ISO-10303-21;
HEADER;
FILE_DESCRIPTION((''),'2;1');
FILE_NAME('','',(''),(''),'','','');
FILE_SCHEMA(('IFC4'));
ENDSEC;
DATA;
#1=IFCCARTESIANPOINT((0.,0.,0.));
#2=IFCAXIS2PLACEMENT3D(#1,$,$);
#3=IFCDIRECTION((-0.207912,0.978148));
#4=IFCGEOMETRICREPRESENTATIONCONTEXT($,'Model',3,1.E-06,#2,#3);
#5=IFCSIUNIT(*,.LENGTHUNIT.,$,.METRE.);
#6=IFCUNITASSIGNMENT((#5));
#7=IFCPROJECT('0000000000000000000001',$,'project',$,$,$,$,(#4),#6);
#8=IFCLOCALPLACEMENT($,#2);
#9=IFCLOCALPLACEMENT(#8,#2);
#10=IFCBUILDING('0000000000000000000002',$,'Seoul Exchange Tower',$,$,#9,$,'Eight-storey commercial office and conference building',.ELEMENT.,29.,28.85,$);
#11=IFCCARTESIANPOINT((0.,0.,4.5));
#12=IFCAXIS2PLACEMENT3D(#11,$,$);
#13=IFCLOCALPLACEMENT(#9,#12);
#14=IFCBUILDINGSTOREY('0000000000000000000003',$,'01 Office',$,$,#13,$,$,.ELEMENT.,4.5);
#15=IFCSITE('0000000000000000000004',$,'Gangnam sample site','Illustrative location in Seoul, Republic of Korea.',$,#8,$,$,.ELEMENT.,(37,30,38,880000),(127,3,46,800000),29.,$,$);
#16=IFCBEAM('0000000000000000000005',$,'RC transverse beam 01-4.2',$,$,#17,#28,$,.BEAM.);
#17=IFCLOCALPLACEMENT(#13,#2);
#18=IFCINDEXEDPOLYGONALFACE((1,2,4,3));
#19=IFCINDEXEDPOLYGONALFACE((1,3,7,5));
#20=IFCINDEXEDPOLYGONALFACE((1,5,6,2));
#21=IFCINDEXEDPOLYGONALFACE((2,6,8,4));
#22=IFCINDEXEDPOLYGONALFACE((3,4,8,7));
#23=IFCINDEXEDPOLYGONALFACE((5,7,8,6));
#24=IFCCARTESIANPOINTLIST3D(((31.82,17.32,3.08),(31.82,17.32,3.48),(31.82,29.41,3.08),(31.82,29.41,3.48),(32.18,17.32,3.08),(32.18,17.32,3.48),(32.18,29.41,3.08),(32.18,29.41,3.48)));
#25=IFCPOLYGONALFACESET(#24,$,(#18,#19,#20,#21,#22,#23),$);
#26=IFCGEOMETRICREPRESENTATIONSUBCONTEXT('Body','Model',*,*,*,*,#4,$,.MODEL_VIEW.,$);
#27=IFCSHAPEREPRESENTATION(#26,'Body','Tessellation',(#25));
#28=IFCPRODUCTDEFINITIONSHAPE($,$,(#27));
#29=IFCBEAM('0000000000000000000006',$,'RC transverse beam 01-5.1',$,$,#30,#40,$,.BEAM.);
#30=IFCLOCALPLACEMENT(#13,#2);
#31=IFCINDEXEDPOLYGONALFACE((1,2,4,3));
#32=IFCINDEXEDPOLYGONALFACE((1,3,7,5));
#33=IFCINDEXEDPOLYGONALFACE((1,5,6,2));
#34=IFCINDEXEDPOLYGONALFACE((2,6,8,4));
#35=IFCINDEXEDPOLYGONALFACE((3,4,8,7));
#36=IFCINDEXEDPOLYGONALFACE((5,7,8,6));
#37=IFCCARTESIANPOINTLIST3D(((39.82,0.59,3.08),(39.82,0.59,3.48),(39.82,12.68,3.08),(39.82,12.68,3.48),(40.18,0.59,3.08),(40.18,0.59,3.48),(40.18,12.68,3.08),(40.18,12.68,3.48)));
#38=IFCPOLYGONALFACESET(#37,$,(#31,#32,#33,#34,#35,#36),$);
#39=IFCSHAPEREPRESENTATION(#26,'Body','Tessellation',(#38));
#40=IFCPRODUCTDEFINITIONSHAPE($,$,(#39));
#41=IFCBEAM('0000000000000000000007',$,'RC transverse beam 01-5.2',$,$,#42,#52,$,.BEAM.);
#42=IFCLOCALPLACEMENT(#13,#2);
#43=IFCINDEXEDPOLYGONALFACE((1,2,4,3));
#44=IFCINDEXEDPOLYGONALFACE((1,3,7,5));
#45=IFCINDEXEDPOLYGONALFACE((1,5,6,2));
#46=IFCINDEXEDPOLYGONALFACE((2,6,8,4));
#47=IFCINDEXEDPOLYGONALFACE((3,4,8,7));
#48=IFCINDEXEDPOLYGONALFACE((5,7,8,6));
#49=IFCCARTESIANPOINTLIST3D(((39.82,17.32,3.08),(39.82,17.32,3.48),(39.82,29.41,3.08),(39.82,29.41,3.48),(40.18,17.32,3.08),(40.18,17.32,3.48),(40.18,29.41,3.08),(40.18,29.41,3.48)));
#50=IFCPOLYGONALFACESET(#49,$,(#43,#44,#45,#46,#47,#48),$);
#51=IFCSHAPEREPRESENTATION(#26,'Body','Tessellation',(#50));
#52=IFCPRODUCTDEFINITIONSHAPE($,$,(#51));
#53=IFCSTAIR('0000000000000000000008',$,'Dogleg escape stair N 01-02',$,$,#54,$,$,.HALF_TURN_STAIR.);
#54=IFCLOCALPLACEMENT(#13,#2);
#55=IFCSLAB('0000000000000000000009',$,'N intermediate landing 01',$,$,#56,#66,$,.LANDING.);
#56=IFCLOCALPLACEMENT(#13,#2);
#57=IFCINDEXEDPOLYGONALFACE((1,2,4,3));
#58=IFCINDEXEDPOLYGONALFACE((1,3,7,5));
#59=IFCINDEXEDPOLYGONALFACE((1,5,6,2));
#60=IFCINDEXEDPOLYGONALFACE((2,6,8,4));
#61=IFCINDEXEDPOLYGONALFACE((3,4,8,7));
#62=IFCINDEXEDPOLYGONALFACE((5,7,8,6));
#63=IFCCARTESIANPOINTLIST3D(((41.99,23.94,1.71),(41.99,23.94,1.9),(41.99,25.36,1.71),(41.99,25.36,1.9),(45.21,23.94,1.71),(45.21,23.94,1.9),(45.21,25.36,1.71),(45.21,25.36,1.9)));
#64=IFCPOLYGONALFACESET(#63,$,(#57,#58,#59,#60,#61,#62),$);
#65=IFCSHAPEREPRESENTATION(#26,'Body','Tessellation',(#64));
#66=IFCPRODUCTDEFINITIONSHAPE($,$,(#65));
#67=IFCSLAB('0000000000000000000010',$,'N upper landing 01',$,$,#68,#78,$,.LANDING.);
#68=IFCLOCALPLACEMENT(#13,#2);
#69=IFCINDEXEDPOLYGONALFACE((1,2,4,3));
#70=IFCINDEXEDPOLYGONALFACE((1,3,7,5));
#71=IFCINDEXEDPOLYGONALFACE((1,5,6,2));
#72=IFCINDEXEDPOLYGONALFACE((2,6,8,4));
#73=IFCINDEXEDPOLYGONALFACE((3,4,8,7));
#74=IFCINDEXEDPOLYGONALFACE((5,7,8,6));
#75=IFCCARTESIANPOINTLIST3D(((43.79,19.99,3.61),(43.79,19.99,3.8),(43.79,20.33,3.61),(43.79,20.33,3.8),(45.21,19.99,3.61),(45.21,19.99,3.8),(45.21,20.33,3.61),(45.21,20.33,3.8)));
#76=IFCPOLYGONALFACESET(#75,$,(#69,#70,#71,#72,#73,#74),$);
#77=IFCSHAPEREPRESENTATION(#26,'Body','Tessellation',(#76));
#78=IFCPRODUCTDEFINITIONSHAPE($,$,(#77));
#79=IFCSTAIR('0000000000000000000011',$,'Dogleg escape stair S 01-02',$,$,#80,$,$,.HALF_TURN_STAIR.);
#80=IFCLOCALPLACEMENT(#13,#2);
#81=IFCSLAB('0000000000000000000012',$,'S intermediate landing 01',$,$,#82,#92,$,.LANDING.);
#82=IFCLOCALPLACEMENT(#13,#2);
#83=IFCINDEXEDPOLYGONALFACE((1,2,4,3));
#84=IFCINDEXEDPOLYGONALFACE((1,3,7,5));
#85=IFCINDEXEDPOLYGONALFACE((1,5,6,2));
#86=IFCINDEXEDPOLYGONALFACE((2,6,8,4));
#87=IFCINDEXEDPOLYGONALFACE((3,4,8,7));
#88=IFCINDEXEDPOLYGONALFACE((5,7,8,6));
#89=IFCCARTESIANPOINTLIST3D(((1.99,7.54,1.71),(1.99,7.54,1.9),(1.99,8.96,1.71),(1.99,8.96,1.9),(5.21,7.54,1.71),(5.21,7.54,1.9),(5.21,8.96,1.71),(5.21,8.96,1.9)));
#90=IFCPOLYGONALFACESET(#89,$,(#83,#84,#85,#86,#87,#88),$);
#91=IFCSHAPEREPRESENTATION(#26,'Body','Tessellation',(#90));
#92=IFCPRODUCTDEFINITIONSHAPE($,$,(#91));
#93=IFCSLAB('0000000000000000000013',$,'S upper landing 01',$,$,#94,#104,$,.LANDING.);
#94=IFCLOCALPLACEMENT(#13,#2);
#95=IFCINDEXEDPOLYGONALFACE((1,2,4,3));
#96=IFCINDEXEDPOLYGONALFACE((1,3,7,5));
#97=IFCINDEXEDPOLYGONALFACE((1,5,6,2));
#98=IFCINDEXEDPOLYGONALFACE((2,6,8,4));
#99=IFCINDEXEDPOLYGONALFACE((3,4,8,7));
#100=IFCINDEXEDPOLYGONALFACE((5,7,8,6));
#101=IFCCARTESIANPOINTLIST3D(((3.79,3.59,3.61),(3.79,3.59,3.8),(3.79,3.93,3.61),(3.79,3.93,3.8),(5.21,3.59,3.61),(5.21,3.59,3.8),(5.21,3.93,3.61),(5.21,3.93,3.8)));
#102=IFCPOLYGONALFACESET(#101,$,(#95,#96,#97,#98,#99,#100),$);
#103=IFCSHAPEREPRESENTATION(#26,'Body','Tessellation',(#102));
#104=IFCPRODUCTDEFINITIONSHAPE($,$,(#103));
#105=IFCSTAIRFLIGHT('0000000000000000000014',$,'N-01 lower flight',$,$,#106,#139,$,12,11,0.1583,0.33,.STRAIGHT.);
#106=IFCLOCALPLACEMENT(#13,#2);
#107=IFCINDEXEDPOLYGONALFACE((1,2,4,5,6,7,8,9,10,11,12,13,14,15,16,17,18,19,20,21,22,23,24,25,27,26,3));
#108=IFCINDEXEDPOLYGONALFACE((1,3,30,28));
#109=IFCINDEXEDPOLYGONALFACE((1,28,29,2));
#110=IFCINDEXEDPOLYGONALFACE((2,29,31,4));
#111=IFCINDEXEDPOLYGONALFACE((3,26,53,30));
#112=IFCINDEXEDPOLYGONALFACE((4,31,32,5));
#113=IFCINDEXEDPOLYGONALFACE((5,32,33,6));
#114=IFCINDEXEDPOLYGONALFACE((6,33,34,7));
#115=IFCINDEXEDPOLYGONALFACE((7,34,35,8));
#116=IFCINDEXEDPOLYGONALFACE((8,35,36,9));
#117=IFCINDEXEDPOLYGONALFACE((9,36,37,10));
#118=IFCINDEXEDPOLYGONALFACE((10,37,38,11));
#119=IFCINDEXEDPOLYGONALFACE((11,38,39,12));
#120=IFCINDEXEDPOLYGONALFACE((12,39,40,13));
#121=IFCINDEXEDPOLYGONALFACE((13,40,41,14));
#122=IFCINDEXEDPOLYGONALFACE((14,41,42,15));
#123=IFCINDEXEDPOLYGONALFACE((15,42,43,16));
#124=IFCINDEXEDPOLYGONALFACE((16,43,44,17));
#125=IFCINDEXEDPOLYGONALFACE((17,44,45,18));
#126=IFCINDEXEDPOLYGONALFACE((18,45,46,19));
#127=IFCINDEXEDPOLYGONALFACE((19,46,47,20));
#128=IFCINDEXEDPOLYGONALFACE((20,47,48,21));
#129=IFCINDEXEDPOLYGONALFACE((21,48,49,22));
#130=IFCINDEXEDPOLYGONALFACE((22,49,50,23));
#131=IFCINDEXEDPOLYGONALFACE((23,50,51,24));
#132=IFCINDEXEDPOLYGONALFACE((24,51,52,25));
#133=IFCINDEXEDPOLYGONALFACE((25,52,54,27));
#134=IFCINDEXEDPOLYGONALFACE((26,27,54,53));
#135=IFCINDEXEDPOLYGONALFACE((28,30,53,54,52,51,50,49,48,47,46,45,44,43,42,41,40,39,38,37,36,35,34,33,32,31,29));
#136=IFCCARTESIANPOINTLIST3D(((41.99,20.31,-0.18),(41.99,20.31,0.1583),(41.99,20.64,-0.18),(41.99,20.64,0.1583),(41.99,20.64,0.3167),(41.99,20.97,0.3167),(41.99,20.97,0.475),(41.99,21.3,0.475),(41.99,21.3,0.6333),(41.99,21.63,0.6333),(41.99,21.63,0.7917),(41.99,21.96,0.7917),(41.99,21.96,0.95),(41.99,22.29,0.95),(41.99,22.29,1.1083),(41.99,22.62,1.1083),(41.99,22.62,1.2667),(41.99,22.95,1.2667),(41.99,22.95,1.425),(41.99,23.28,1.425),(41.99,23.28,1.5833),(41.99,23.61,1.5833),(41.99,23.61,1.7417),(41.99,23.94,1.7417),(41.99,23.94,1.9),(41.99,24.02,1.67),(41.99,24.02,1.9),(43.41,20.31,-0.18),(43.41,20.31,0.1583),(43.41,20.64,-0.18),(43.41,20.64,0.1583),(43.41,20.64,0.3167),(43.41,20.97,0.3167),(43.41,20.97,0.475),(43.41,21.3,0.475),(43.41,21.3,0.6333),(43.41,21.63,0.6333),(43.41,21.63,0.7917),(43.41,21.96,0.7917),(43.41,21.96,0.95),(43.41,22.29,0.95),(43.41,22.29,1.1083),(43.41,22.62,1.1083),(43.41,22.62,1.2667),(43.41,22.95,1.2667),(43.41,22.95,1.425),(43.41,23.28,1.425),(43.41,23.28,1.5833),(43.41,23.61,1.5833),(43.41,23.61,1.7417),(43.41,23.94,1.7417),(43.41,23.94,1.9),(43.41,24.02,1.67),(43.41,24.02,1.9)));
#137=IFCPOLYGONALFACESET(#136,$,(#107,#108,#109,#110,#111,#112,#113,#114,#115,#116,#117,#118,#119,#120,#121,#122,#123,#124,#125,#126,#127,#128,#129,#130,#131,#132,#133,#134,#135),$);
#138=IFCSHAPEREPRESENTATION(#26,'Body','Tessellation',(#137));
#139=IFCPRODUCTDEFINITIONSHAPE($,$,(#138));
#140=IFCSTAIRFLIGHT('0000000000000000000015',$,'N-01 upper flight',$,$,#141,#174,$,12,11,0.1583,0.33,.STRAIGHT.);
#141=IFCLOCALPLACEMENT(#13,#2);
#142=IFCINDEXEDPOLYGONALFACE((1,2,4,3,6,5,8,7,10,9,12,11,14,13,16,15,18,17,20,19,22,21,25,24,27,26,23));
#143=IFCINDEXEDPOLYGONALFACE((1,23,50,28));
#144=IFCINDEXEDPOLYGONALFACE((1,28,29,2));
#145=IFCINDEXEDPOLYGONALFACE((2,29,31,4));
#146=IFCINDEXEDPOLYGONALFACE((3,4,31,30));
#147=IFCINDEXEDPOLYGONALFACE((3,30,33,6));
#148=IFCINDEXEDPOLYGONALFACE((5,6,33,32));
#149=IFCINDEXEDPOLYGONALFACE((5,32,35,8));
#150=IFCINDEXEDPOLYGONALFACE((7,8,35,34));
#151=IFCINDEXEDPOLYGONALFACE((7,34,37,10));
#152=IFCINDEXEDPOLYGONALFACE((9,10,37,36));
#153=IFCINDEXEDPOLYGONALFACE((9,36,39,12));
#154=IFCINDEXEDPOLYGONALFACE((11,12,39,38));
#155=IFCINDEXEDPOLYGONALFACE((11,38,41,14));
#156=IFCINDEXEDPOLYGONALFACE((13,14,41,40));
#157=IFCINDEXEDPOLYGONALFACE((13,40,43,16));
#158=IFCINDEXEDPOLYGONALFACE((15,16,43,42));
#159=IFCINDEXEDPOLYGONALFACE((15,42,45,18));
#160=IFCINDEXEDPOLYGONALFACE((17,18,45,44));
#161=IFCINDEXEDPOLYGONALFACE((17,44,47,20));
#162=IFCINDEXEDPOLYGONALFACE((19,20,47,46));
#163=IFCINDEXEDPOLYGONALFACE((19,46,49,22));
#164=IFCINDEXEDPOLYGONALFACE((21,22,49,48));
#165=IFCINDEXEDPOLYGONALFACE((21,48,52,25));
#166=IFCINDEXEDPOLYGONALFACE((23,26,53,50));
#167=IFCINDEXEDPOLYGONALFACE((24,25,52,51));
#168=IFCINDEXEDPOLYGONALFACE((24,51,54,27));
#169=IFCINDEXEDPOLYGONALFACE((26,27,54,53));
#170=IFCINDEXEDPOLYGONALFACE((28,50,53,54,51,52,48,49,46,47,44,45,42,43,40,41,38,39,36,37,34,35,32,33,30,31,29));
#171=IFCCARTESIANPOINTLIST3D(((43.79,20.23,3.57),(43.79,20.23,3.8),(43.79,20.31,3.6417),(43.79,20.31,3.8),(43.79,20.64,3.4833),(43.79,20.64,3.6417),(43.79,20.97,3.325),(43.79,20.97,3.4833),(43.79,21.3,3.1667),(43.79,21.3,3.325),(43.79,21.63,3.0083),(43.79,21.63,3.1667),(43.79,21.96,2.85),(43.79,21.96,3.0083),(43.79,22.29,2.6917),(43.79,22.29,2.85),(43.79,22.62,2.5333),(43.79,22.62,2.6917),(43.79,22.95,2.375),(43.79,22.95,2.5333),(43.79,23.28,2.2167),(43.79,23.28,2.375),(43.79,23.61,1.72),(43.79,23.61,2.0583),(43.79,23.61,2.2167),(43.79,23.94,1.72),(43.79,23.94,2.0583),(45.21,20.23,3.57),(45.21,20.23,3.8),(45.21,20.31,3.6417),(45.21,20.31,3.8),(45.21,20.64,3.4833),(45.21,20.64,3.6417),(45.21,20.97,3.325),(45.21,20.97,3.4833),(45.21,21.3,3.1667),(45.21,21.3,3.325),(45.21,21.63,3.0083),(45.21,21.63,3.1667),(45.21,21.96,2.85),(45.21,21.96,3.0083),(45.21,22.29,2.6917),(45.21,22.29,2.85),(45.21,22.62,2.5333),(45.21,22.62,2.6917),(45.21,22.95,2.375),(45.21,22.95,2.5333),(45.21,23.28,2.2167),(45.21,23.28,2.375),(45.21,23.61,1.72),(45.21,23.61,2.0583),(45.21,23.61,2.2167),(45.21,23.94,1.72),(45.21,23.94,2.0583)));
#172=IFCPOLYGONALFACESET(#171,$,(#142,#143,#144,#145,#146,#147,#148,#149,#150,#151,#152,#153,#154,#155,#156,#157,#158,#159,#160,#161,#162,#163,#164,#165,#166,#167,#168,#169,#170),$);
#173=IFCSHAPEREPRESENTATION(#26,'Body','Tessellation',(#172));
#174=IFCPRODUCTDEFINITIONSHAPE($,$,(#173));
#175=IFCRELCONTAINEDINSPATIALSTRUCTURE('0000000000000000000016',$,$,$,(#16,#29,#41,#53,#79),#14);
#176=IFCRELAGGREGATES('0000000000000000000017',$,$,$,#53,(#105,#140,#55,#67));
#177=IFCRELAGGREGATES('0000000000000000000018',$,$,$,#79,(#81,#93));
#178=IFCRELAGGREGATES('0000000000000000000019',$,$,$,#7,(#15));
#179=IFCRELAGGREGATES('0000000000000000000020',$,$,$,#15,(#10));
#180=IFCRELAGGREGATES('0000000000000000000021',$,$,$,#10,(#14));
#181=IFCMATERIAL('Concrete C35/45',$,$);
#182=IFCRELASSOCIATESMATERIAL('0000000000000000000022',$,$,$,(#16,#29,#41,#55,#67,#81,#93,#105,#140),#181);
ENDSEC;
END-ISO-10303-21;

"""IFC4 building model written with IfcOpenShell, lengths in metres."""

from ifc_helpers import new_model, si_unit, direction, frame, frame_2d, origin, place, context, subcontext, project, spatial, polyline, rectangle, outline, extrude, material, element, aggregate, save


model = new_model("IFC4")

# Units and contexts
model_context = context("Model", 3, precision=1e-06, world=origin(), true_north=direction((-0.207912, 0.978148)))
body_context = subcontext(model_context, "Body", "Model", "MODEL_VIEW")
ifc_project = project(units=[si_unit("LENGTHUNIT", "METRE")], contexts=[model_context])

# Site, building, storey
site_placement = place(None, origin())
site = spatial("IfcSite", under=ifc_project, at=site_placement, Name="Gangnam sample site", Description="Illustrative location in Seoul, Republic of Korea.", CompositionType="ELEMENT", RefLatitude=(37, 30, 38, 880000), RefLongitude=(127, 3, 46, 800000), RefElevation=29.0)
building_placement = place(site_placement, origin())
building = spatial("IfcBuilding", under=site, at=building_placement, Name="Seoul Exchange Tower", LongName="Eight-storey commercial office and conference building", CompositionType="ELEMENT", ElevationOfRefHeight=29.0, ElevationOfTerrain=28.85)
storey_placement = place(building_placement, frame((0.0, 0.0, 4.5)))
storey = spatial("IfcBuildingStorey", under=building, at=storey_placement, Name="01 Office", CompositionType="ELEMENT", Elevation=4.5)

# Beams
ifc_material_1 = material(Name="Concrete C35/45")
placement_1 = place(storey_placement, origin())
element("IfcBeam", 1, at=placement_1, inside=storey, material=ifc_material_1, Name="RC transverse beam 01-4.2", PredefinedType="BEAM", context=body_context, shape_type="SweptSolid", body=[
    extrude(rectangle(XDim=0.36, YDim=12.09, at=frame_2d((0.18, 6.045))), frame((31.82, 17.32, 3.08)), (0.0, 0.0, 1.0), 0.4),
])
element("IfcBeam", 2, at=placement_1, inside=storey, material=ifc_material_1, Name="RC transverse beam 01-5.1", PredefinedType="BEAM", context=body_context, shape_type="SweptSolid", body=[
    extrude(rectangle(XDim=0.36, YDim=12.09, at=frame_2d((0.18, 6.045))), frame((39.82, 0.59, 3.08)), (0.0, 0.0, 1.0), 0.4),
])
element("IfcBeam", 3, at=placement_1, inside=storey, material=ifc_material_1, Name="RC transverse beam 01-5.2", PredefinedType="BEAM", context=body_context, shape_type="SweptSolid", body=[
    extrude(rectangle(XDim=0.36, YDim=12.09, at=frame_2d((0.18, 6.045))), frame((39.82, 17.32, 3.08)), (0.0, 0.0, 1.0), 0.4),
])

# Stairs, slabs
stair_1 = element("IfcStair", 4, at=placement_1, inside=storey, Name="Dogleg escape stair N 01-02", PredefinedType="HALF_TURN_STAIR")
placement_2 = place(placement_1, origin())
slab_1 = element("IfcSlab", 5, at=placement_2, material=ifc_material_1, Name="N intermediate landing 01", PredefinedType="LANDING", context=body_context, shape_type="SweptSolid", body=[
    extrude(rectangle(XDim=3.22, YDim=1.42, at=frame_2d((1.61, 0.71))), frame((41.99, 23.94, 1.71)), (0.0, 0.0, 1.0), 0.19),
])
slab_2 = element("IfcSlab", 6, at=placement_2, material=ifc_material_1, Name="N upper landing 01", PredefinedType="LANDING", context=body_context, shape_type="SweptSolid", body=[
    extrude(rectangle(XDim=1.42, YDim=0.34, at=frame_2d((0.71, 0.17))), frame((43.79, 19.99, 3.61)), (0.0, 0.0, 1.0), 0.19),
])
stair_2 = element("IfcStair", 7, at=placement_1, inside=storey, Name="Dogleg escape stair S 01-02", PredefinedType="HALF_TURN_STAIR")
slab_3 = element("IfcSlab", 8, at=placement_2, material=ifc_material_1, Name="S intermediate landing 01", PredefinedType="LANDING", context=body_context, shape_type="SweptSolid", body=[
    extrude(rectangle(XDim=3.22, YDim=1.42, at=frame_2d((1.61, 0.71))), frame((1.99, 7.54, 1.71)), (0.0, 0.0, 1.0), 0.19),
])
slab_4 = element("IfcSlab", 9, at=placement_2, material=ifc_material_1, Name="S upper landing 01", PredefinedType="LANDING", context=body_context, shape_type="SweptSolid", body=[
    extrude(rectangle(XDim=1.42, YDim=0.34, at=frame_2d((0.71, 0.17))), frame((3.79, 3.59, 3.61)), (0.0, 0.0, 1.0), 0.19),
])

# Stair flights
stair_flight_1 = element("IfcStairFlight", 10, at=placement_2, material=ifc_material_1, Name="N-01 lower flight", NumberOfRisers=12, NumberOfTreads=11, PredefinedType="STRAIGHT", RiserHeight=0.1583, TreadLength=0.33, context=body_context, shape_type="SweptSolid", body=[
    extrude(outline(polyline([(0.0, -0.18), (0.0, 0.1583), (0.33, 0.1583), (0.33, 0.3167), (0.66, 0.3167), (0.66, 0.475), (0.99, 0.475), (0.99, 0.6333), (1.32, 0.6333), (1.32, 0.7917), (1.65, 0.7917), (1.65, 0.95), (1.98, 0.95), (1.98, 1.1083), (2.31, 1.1083), (2.31, 1.2667), (2.64, 1.2667), (2.64, 1.425), (2.97, 1.425), (2.97, 1.5833), (3.3, 1.5833), (3.3, 1.7417), (3.63, 1.7417), (3.63, 1.9), (3.71, 1.9), (3.71, 1.67), (0.33, -0.18), (0.0, -0.18)])), frame((41.99, 20.31, 0.0), z_axis=(1.0, 0.0, 0.0), x_axis=(0.0, 1.0, 0.0)), (0.0, 0.0, 1.0), 1.42),
])
stair_flight_2 = element("IfcStairFlight", 11, at=placement_2, material=ifc_material_1, Name="N-01 upper flight", NumberOfRisers=12, NumberOfTreads=11, PredefinedType="STRAIGHT", RiserHeight=0.1583, TreadLength=0.33, context=body_context, shape_type="SweptSolid", body=[
    extrude(outline(polyline([(0.0, -0.18), (0.0, 0.1583), (0.33, 0.1583), (0.33, 0.3167), (0.66, 0.3167), (0.66, 0.475), (0.99, 0.475), (0.99, 0.6333), (1.32, 0.6333), (1.32, 0.7917), (1.65, 0.7917), (1.65, 0.95), (1.98, 0.95), (1.98, 1.1083), (2.31, 1.1083), (2.31, 1.2667), (2.64, 1.2667), (2.64, 1.425), (2.97, 1.425), (2.97, 1.5833), (3.3, 1.5833), (3.3, 1.7417), (3.63, 1.7417), (3.63, 1.9), (3.71, 1.9), (3.71, 1.67), (0.33, -0.18), (0.0, -0.18)])), frame((45.21, 23.94, 1.9), z_axis=(-1.0, 0.0, 0.0), x_axis=(0.0, -1.0, 0.0)), (0.0, 0.0, 1.0), 1.42),
])

aggregate(stair_1, [stair_flight_1, stair_flight_2, slab_1, slab_2])
aggregate(stair_2, [slab_3, slab_4])

save(model, "model.ifc")
